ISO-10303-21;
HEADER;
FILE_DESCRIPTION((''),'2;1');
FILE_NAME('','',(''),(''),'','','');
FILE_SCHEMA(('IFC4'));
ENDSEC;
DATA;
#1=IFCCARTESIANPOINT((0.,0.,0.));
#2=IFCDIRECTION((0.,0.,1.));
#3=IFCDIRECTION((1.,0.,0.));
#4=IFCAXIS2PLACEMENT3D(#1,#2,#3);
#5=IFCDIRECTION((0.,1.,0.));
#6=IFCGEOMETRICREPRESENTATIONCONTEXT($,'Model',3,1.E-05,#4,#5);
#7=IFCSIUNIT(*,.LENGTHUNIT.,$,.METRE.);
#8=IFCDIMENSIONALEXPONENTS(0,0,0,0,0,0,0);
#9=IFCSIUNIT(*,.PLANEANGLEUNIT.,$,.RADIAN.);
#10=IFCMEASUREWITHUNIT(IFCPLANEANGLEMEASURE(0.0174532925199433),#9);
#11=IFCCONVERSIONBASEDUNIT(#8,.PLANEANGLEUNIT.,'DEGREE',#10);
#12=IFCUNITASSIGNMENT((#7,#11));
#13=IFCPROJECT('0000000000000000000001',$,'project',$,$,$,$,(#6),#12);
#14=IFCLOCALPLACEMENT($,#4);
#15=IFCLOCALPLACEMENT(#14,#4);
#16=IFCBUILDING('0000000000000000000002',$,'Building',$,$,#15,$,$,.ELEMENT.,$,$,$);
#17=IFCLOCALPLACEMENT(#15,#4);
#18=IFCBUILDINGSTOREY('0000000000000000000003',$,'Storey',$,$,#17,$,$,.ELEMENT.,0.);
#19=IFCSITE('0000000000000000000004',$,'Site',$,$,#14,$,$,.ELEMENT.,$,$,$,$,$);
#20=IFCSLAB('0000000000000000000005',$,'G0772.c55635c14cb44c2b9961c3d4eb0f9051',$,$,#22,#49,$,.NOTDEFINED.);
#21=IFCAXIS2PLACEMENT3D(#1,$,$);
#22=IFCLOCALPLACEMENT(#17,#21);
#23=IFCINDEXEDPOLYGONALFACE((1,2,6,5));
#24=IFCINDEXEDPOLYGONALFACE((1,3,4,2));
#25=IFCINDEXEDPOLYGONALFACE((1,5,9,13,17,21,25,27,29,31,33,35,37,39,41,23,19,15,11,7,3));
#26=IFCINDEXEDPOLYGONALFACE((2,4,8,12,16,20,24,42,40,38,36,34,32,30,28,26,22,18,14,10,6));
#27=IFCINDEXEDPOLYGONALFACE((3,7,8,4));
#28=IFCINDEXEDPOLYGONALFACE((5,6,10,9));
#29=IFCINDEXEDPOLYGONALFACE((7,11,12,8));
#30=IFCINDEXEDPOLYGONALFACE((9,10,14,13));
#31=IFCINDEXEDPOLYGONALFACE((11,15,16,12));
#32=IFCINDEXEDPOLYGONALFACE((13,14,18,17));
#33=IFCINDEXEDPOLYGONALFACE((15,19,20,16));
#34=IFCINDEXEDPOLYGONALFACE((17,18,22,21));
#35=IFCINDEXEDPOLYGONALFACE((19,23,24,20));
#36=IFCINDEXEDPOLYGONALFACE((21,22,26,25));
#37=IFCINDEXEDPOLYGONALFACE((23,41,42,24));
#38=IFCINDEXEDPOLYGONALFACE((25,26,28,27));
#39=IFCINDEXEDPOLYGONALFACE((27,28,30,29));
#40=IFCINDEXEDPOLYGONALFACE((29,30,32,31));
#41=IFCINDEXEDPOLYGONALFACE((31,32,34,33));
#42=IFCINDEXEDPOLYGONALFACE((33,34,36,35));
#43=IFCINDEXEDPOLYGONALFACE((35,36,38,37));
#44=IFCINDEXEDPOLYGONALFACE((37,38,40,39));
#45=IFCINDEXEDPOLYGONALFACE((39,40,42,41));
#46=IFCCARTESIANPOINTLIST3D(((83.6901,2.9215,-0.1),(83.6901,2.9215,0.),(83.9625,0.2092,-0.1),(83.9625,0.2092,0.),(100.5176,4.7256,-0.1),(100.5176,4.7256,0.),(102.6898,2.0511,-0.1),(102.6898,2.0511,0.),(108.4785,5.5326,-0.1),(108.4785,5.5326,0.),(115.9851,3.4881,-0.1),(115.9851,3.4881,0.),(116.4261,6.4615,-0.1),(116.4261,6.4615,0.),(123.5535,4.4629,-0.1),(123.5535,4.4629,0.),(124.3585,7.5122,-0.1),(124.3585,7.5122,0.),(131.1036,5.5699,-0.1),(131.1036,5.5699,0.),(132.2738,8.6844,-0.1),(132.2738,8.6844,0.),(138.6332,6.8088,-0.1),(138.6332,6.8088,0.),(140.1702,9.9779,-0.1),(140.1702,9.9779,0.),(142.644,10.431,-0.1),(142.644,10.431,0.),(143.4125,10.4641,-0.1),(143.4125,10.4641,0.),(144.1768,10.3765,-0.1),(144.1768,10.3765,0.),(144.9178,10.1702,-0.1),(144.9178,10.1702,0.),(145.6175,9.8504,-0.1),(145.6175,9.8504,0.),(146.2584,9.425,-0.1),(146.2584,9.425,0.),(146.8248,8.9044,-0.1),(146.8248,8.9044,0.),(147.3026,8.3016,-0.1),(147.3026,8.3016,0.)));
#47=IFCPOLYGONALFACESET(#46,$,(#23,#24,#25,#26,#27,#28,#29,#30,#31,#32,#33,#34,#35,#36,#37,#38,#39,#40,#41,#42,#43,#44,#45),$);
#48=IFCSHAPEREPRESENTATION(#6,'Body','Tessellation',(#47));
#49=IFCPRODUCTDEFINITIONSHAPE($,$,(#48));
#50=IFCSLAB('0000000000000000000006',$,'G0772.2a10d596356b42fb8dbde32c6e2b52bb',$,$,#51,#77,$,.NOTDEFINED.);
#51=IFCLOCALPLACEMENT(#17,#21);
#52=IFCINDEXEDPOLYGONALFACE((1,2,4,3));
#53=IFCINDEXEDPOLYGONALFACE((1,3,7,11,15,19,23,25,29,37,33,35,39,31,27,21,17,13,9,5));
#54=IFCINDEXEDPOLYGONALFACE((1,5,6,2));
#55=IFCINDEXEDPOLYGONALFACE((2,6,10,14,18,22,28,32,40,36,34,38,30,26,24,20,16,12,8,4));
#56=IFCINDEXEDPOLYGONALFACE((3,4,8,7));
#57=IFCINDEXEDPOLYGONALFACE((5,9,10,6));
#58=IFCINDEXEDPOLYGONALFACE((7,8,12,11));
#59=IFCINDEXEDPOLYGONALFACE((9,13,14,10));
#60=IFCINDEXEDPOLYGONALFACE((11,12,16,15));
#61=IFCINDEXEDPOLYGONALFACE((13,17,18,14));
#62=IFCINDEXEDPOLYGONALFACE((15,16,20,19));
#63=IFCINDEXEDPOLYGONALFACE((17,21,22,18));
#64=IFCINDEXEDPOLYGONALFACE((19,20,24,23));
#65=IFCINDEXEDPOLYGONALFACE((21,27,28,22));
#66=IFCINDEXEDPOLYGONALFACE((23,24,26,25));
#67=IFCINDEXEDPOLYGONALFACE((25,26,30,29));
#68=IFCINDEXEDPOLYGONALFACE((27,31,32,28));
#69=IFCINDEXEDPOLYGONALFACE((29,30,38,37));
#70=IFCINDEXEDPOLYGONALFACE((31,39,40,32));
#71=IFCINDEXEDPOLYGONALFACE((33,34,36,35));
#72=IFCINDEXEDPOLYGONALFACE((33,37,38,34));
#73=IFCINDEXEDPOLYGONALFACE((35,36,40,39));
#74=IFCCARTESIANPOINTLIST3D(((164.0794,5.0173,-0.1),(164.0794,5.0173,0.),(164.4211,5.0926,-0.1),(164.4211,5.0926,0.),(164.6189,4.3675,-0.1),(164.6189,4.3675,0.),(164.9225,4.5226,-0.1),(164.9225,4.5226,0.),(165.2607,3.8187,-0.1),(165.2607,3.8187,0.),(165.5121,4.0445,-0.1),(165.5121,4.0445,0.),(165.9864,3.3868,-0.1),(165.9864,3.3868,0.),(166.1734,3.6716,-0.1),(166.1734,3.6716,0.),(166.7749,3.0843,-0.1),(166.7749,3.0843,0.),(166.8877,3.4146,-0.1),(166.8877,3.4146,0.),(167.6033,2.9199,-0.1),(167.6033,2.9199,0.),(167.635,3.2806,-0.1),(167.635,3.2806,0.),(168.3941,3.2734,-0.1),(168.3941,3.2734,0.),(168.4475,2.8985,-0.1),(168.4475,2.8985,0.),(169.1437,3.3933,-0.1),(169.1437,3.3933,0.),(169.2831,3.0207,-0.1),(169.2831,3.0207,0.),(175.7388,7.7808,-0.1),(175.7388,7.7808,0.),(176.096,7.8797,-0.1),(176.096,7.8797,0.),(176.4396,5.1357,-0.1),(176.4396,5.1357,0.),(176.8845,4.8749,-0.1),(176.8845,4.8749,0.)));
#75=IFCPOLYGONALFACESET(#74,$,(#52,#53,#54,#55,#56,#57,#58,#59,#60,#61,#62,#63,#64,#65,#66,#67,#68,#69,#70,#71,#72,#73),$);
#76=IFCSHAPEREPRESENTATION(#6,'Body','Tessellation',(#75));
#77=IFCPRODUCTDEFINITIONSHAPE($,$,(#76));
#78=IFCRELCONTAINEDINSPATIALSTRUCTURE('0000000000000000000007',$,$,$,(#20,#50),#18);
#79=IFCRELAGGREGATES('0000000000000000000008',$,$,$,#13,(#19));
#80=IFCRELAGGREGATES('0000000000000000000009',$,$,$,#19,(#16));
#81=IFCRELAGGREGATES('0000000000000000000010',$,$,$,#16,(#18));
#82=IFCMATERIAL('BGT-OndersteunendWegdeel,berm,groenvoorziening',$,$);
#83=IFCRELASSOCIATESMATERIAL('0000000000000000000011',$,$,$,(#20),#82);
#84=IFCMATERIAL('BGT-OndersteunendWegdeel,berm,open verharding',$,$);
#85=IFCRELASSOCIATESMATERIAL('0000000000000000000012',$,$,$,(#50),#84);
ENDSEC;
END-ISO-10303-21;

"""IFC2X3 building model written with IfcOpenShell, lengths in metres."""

from ifc_helpers import new_model, entity, si_unit, converted_unit, direction, frame, origin_with_axes, place, context, project, spatial, polyline, outline, extrude, material, element, save


model = new_model("IFC2X3")

# Units and contexts
model_context = context("Model", 3, precision=1e-05, world=origin_with_axes(), true_north=direction((0.0, 1.0, 0.0)))
ifc_project = project(units=[si_unit("LENGTHUNIT", "METRE"), converted_unit("PLANEANGLEUNIT", "DEGREE", entity("IfcPlaneAngleMeasure", 0.0174532925199433), si_unit("PLANEANGLEUNIT", "RADIAN"), dimensions=[0, 0, 0, 0, 0, 0, 0])], contexts=[model_context])

# Site, building, storey
site_placement = place(None, origin_with_axes())
site = spatial("IfcSite", under=ifc_project, at=site_placement, Name="Site", CompositionType="ELEMENT")
building_placement = place(site_placement, origin_with_axes())
building = spatial("IfcBuilding", under=site, at=building_placement, Name="Building", CompositionType="ELEMENT")
storey_placement = place(building_placement, origin_with_axes())
storey = spatial("IfcBuildingStorey", under=building, at=storey_placement, Name="Storey", CompositionType="ELEMENT", Elevation=0.0)

# Slabs
ifc_material_1 = material(Name="BGT-OndersteunendWegdeel,berm,open verharding")
ifc_material_2 = material(Name="BGT-OndersteunendWegdeel,berm,groenvoorziening")
slab_1_placement = place(storey_placement, frame((0.0, 0.0, -0.1), z_axis=(0.0, 0.0, 1.0), x_axis=(1.0, 0.0, 0.0)))
element("IfcSlab", 1, at=slab_1_placement, inside=storey, material=ifc_material_2, Name="G0772.c55635c14cb44c2b9961c3d4eb0f9051", PredefinedType="NOTDEFINED", context=model_context, shape_type="SweptSolid", body=[
    extrude(outline(polyline([(83.6901, 2.9215), (100.5176, 4.7256), (108.4785, 5.5326), (116.4261, 6.4615), (124.3585, 7.5122), (132.2738, 8.6844), (140.1702, 9.9779), (142.644, 10.431), (143.4125, 10.4641), (144.1768, 10.3765), (144.9178, 10.1702), (145.6175, 9.8504), (146.2584, 9.425), (146.8248, 8.9044), (147.3026, 8.3016), (138.6332, 6.8088), (131.1036, 5.5699), (123.5535, 4.4629), (115.9851, 3.4881), (102.6898, 2.0511), (83.9625, 0.2092), (83.6901, 2.9215)])), origin_with_axes(), (0.0, 0.0, 1.0), 0.1),
])
slab_2_placement = place(storey_placement, frame((0.0, 0.0, -0.1), z_axis=(0.0, 0.0, 1.0), x_axis=(1.0, 0.0, 0.0)))
element("IfcSlab", 2, at=slab_2_placement, inside=storey, material=ifc_material_1, Name="G0772.2a10d596356b42fb8dbde32c6e2b52bb", PredefinedType="NOTDEFINED", context=model_context, shape_type="SweptSolid", body=[
    extrude(outline(polyline([(164.9225, 4.5226), (165.5121, 4.0445), (166.1734, 3.6716), (166.8877, 3.4146), (167.635, 3.2806), (168.3941, 3.2734), (169.1437, 3.3933), (176.4396, 5.1357), (175.7388, 7.7808), (176.096, 7.8797), (176.8845, 4.8749), (169.2831, 3.0207), (168.4475, 2.8985), (167.6033, 2.9199), (166.7749, 3.0843), (165.9864, 3.3868), (165.2607, 3.8187), (164.6189, 4.3675), (164.0794, 5.0173), (164.4211, 5.0926), (164.9225, 4.5226)])), origin_with_axes(), (0.0, 0.0, 1.0), 0.1),
])

save(model, "model.ifc")
